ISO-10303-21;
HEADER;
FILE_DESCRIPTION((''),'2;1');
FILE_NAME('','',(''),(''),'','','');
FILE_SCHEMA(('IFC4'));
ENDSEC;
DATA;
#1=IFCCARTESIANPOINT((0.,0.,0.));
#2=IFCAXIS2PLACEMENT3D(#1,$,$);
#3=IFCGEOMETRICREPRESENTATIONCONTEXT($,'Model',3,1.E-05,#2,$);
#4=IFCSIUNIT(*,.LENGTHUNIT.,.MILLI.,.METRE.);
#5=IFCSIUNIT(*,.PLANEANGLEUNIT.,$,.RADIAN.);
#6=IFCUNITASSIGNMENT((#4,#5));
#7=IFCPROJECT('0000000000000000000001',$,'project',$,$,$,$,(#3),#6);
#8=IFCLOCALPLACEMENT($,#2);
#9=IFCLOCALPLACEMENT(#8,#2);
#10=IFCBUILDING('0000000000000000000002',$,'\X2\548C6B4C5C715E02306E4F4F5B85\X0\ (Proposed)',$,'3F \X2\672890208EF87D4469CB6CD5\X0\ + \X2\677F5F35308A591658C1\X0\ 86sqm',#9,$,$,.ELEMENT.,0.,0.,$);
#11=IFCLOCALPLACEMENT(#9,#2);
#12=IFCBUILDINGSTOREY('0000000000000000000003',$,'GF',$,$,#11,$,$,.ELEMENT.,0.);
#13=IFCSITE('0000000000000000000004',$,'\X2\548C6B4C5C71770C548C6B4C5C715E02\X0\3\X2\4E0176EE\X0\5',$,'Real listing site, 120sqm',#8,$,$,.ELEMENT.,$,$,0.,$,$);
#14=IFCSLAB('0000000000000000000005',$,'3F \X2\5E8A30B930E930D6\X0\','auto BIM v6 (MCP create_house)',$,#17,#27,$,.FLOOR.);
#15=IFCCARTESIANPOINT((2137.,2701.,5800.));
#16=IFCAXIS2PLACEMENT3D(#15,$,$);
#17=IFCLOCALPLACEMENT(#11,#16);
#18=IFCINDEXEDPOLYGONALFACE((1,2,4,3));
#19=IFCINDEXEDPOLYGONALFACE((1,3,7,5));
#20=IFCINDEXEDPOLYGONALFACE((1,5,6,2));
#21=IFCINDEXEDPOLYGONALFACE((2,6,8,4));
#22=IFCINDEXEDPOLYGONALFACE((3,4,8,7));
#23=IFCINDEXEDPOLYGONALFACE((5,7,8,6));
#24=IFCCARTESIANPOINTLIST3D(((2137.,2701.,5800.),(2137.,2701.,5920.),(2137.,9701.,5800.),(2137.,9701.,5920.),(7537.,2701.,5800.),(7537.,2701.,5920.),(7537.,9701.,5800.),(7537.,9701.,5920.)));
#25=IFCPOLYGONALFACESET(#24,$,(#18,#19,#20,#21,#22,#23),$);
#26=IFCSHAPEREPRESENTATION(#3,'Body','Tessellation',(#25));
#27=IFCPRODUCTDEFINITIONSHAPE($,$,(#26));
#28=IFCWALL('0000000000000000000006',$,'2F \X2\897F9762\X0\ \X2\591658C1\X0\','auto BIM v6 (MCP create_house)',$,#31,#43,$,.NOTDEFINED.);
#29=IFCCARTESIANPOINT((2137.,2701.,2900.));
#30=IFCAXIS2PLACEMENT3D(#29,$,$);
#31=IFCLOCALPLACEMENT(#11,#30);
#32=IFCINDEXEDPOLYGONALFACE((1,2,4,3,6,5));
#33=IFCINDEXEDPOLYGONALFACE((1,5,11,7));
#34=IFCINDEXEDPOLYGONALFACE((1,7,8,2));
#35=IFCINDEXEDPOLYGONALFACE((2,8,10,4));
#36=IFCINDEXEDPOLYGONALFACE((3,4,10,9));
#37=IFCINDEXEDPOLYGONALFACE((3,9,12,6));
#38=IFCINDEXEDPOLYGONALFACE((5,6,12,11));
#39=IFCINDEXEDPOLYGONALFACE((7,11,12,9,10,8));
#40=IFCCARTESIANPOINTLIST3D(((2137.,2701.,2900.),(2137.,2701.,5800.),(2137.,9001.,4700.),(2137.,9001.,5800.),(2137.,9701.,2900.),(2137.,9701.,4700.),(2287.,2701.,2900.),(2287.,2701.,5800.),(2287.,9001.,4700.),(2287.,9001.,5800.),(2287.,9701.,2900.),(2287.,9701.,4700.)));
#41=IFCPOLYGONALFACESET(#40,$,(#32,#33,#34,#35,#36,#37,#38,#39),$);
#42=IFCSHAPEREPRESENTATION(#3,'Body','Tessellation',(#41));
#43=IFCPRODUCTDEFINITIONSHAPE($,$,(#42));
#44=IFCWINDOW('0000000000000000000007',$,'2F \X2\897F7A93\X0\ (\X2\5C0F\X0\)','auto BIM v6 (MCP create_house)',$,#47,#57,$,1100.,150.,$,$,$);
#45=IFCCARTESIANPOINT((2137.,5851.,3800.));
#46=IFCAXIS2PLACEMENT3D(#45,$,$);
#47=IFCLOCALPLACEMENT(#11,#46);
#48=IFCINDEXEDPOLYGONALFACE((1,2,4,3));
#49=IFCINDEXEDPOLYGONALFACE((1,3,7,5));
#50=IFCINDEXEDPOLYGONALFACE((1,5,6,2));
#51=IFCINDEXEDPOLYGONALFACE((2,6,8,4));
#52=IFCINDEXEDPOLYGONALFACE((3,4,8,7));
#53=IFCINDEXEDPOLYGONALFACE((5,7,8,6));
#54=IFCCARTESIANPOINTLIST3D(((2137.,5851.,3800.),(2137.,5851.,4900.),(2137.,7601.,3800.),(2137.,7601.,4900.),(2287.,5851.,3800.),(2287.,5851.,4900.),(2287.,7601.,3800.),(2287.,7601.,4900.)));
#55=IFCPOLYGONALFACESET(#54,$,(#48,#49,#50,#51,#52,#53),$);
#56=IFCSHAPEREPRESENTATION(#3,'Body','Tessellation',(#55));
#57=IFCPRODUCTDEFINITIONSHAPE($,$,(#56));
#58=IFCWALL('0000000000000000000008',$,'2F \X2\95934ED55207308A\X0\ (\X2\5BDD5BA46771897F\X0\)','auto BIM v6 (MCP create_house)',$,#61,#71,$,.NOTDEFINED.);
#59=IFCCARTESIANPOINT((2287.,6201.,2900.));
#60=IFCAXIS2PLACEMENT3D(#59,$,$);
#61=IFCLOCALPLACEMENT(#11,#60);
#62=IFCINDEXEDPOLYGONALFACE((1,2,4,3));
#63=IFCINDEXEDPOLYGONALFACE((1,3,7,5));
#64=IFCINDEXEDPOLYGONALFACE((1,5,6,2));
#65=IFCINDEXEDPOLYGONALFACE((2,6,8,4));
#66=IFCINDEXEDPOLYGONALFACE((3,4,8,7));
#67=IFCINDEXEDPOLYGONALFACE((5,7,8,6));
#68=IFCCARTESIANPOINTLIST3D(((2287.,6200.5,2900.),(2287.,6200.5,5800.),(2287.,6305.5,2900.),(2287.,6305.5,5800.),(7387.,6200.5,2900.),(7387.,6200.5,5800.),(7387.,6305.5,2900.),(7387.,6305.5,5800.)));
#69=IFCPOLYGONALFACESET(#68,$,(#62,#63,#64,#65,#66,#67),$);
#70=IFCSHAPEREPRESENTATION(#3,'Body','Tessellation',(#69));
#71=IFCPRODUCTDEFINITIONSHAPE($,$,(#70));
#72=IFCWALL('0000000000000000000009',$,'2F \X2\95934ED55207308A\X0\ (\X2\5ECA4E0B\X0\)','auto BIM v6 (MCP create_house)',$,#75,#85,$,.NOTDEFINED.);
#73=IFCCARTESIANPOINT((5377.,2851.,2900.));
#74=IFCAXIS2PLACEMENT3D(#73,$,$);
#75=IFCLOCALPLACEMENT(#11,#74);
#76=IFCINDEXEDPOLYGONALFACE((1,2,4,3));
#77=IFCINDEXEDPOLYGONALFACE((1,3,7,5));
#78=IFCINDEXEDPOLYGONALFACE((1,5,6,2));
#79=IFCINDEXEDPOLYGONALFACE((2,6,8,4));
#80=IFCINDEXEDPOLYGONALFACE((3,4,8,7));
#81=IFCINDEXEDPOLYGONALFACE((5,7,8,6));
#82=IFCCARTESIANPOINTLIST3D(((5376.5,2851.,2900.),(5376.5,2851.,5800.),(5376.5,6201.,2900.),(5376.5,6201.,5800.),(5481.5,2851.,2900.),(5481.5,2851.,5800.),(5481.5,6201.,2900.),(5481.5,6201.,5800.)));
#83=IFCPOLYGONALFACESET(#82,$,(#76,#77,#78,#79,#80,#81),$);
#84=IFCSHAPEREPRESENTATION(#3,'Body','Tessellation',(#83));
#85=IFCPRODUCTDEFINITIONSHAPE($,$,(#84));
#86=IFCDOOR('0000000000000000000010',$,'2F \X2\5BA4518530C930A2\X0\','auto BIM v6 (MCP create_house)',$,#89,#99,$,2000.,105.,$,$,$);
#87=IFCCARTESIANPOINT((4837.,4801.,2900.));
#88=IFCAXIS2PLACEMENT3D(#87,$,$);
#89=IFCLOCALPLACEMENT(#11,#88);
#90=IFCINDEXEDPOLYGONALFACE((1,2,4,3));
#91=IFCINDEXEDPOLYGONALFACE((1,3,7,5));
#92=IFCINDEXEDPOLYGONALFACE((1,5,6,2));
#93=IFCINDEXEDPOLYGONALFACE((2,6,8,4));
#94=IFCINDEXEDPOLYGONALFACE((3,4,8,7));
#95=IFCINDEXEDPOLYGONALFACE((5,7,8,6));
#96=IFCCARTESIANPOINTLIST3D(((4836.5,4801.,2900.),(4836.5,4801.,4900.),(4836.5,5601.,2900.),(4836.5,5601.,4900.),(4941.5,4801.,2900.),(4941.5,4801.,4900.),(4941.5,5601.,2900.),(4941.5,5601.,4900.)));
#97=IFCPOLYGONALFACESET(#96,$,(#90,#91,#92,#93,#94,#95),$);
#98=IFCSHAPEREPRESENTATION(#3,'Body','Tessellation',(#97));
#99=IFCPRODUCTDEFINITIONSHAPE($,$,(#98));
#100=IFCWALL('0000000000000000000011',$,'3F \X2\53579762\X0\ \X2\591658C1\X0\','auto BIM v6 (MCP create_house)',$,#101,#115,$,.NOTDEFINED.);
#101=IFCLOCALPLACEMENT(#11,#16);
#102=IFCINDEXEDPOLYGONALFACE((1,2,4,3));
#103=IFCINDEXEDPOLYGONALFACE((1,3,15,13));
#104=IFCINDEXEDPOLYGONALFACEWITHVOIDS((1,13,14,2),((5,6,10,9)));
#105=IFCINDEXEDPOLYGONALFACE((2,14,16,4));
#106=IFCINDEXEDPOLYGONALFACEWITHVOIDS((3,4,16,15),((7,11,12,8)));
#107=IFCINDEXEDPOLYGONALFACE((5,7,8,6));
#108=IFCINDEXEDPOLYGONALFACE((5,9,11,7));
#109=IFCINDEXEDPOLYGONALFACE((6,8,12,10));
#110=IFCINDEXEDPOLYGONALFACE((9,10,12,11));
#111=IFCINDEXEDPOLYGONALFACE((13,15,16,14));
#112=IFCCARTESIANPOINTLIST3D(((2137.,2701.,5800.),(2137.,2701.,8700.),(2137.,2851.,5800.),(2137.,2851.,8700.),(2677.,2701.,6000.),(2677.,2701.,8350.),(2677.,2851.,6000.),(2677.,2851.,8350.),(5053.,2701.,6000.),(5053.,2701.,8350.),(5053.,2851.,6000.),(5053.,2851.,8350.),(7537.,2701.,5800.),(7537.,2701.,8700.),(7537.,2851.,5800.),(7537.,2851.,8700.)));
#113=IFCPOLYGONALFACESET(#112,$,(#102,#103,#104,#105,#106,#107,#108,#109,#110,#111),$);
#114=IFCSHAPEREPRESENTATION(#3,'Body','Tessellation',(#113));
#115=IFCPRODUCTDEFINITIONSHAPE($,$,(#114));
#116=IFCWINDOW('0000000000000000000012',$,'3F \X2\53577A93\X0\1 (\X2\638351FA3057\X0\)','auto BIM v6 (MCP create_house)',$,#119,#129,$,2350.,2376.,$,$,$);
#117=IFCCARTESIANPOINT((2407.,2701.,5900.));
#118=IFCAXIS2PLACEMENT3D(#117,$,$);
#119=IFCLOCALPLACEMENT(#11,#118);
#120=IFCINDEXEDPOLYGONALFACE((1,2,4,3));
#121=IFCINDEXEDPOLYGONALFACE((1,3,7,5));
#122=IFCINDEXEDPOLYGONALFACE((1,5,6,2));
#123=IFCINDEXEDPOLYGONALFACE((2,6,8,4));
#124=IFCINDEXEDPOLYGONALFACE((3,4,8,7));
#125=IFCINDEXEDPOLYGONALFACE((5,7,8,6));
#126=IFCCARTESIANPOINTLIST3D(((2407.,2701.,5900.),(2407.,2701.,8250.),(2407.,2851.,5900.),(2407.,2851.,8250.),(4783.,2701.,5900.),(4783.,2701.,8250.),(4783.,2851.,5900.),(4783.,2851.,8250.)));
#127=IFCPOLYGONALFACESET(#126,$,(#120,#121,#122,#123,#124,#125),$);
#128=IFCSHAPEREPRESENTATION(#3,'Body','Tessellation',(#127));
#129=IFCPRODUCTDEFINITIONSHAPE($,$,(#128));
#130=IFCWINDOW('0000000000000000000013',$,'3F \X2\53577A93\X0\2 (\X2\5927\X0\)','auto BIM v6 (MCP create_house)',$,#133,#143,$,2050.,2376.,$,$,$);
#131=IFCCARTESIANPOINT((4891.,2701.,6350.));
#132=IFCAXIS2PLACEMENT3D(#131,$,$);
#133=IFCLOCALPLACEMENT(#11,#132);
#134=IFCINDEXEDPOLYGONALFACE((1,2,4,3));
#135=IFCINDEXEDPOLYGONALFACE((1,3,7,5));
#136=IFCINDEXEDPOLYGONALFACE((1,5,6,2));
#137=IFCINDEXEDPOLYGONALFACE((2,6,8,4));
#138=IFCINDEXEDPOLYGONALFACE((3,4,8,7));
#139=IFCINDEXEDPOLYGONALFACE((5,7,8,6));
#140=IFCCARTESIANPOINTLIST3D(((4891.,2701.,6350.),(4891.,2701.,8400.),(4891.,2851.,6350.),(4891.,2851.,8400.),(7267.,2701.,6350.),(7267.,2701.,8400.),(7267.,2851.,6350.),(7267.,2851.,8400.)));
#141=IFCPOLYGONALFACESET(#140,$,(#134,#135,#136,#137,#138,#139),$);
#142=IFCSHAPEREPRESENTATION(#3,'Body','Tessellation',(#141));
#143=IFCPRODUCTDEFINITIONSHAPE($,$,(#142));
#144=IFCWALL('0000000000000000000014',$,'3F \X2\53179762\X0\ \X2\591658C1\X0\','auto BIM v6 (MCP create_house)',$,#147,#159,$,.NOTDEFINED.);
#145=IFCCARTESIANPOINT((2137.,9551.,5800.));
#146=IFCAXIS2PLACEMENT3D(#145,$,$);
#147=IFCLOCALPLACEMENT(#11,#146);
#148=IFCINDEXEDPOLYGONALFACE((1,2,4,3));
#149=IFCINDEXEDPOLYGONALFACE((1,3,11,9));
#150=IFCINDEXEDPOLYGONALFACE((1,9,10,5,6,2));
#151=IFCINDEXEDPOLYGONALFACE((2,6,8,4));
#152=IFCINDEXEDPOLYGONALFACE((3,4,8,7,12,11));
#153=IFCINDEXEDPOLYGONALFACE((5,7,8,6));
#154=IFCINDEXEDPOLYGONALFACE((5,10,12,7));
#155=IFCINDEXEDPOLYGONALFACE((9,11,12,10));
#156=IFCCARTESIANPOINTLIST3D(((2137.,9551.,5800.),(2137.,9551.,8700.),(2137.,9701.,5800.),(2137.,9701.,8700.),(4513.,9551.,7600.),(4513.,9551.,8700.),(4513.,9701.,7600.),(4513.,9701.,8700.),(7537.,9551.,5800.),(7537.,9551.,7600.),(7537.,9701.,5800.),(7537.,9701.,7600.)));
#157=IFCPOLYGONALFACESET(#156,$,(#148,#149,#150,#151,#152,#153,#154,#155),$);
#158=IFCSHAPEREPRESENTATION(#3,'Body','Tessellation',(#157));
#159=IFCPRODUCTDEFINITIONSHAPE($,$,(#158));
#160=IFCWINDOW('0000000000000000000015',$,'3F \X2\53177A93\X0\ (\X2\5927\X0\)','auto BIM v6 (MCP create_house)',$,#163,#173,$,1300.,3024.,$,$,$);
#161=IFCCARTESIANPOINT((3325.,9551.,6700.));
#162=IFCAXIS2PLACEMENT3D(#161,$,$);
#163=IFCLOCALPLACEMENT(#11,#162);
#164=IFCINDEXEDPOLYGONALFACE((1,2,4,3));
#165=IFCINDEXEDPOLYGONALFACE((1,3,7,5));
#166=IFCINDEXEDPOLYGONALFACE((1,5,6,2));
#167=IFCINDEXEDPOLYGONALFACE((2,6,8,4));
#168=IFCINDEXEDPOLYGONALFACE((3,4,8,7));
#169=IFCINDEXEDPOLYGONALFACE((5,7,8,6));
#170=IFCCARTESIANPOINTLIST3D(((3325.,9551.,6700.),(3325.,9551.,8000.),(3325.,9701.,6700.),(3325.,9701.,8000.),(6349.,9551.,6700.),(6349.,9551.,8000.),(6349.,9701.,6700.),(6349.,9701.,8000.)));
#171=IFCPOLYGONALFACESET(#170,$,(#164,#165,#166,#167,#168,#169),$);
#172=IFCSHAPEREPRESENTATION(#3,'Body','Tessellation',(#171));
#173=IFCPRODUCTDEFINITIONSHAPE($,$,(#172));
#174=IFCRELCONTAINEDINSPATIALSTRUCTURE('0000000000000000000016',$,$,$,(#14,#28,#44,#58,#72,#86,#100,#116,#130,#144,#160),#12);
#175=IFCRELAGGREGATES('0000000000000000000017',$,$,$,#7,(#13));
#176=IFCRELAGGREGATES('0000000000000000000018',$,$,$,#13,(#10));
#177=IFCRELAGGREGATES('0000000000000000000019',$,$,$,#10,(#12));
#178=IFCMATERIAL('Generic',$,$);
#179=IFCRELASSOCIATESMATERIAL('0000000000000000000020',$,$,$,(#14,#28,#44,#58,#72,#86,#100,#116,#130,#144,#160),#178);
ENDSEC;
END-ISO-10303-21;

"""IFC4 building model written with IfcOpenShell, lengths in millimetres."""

from ifc_helpers import new_model, si_unit, frame, frame_2d, origin, place, context, project, spatial, rectangle, extrude, material, element, fill, save


model = new_model("IFC4")

# Units and contexts
model_context = context("Model", 3, precision=1e-05, world=origin())
ifc_project = project(units=[si_unit("LENGTHUNIT", "METRE", prefix="MILLI"), si_unit("PLANEANGLEUNIT", "RADIAN")], contexts=[model_context])

# Site, building, storey
site_placement = place(None, origin())
site = spatial("IfcSite", under=ifc_project, at=site_placement, Name="和歌山県和歌山市3丁目5", ObjectType="Real listing site, 120sqm", CompositionType="ELEMENT", RefElevation=0.0)
building_placement = place(site_placement, origin())
building = spatial("IfcBuilding", under=site, at=building_placement, Name="和歌山市の住宅 (Proposed)", ObjectType="3F 木造軸組構法 + 板張り外壁 86sqm", CompositionType="ELEMENT", ElevationOfRefHeight=0.0, ElevationOfTerrain=0.0)
storey_placement = place(building_placement, origin())
storey = spatial("IfcBuildingStorey", under=building, at=storey_placement, Name="GF", CompositionType="ELEMENT", Elevation=0.0)

# Slab
ifc_material = material(Name="Generic")
slab_placement = place(storey_placement, frame((2137.0, 2701.0, 5800.0)))
element("IfcSlab", 1, at=slab_placement, inside=storey, material=ifc_material, Name="3F 床スラブ", Description="auto BIM v6 (MCP create_house)", PredefinedType="FLOOR", context=model_context, shape_type="SweptSolid", body=[
    extrude(rectangle(XDim=5400.0, YDim=7000.0, at=frame_2d((2700.0, 3500.0))), frame((2137.0, 2701.0, 5800.0)), (0.0, 0.0, 1.0), 120.0),
])

# Wall, opening, window
wall_1_placement = place(storey_placement, frame((2137.0, 2701.0, 2900.0)))
wall_1 = element("IfcWall", 2, at=wall_1_placement, inside=storey, material=ifc_material, Name="2F 西面 外壁", Description="auto BIM v6 (MCP create_house)", PredefinedType="NOTDEFINED", context=model_context, shape_type="SweptSolid", body=[
    extrude(rectangle(XDim=150.0, YDim=7000.0, at=frame_2d((75.0, 3500.0))), frame((2137.0, 2701.0, 2900.0)), (0.0, 0.0, 1.0), 2900.0),
])
opening_1_placement = place(storey_placement, frame((2137.0, 5851.0, 3800.0)))
opening_1 = element("IfcOpeningElement", 3, at=opening_1_placement, cuts=wall_1, PredefinedType="NOTDEFINED", context=model_context, shape_type="SweptSolid", body=[
    extrude(rectangle(XDim=150.0, YDim=1750.0, at=frame_2d((75.0, 875.0))), frame((2137.0, 5851.0, 3800.0)), (0.0, 0.0, 1.0), 1100.0),
])
window_1_placement = place(storey_placement, frame((2137.0, 5851.0, 3800.0)))
window_1 = element("IfcWindow", 4, at=window_1_placement, inside=storey, material=ifc_material, Name="2F 西窓 (小)", Description="auto BIM v6 (MCP create_house)", OverallHeight=1100.0, OverallWidth=150.0, context=model_context, shape_type="SweptSolid", body=[
    extrude(rectangle(XDim=150.0, YDim=1750.0, at=frame_2d((75.0, 875.0))), frame((2137.0, 5851.0, 3800.0)), (0.0, 0.0, 1.0), 1100.0),
])
fill(opening_1, window_1)

# Walls
wall_2_placement = place(storey_placement, frame((2287.0, 6201.0, 2900.0)))
element("IfcWall", 5, at=wall_2_placement, inside=storey, material=ifc_material, Name="2F 間仕切り (寝室東西)", Description="auto BIM v6 (MCP create_house)", PredefinedType="NOTDEFINED", context=model_context, shape_type="SweptSolid", body=[
    extrude(rectangle(XDim=5100.0, YDim=105.0, at=frame_2d((2550.0, 52.0))), frame((2287.0, 6201.0, 2900.0)), (0.0, 0.0, 1.0), 2900.0),
])
wall_3_placement = place(storey_placement, frame((5377.0, 2851.0, 2900.0)))
element("IfcWall", 6, at=wall_3_placement, inside=storey, material=ifc_material, Name="2F 間仕切り (廊下)", Description="auto BIM v6 (MCP create_house)", PredefinedType="NOTDEFINED", context=model_context, shape_type="SweptSolid", body=[
    extrude(rectangle(XDim=105.0, YDim=3350.0, at=frame_2d((52.0, 1675.0))), frame((5377.0, 2851.0, 2900.0)), (0.0, 0.0, 1.0), 2900.0),
])

# Door
door_1_placement = place(storey_placement, frame((4837.0, 4801.0, 2900.0)))
element("IfcDoor", 7, at=door_1_placement, inside=storey, material=ifc_material, Name="2F 室内ドア", Description="auto BIM v6 (MCP create_house)", OverallHeight=2000.0, OverallWidth=105.0, context=model_context, shape_type="SweptSolid", body=[
    extrude(rectangle(XDim=105.0, YDim=800.0, at=frame_2d((52.0, 400.0))), frame((4837.0, 4801.0, 2900.0)), (0.0, 0.0, 1.0), 2000.0),
])

# Wall, openings, windows
wall_4_placement = place(storey_placement, frame((2137.0, 2701.0, 5800.0)))
wall_4 = element("IfcWall", 8, at=wall_4_placement, inside=storey, material=ifc_material, Name="3F 南面 外壁", Description="auto BIM v6 (MCP create_house)", PredefinedType="NOTDEFINED", context=model_context, shape_type="SweptSolid", body=[
    extrude(rectangle(XDim=5400.0, YDim=150.0, at=frame_2d((2700.0, 75.0))), frame((2137.0, 2701.0, 5800.0)), (0.0, 0.0, 1.0), 2900.0),
])
opening_2_placement = place(storey_placement, frame((2407.0, 2701.0, 5900.0)))
opening_2 = element("IfcOpeningElement", 9, at=opening_2_placement, cuts=wall_4, PredefinedType="NOTDEFINED", context=model_context, shape_type="SweptSolid", body=[
    extrude(rectangle(XDim=2376.0, YDim=150.0, at=frame_2d((1188.0, 75.0))), frame((2407.0, 2701.0, 5900.0)), (0.0, 0.0, 1.0), 2350.0),
])
opening_3_placement = place(storey_placement, frame((4891.0, 2701.0, 6350.0)))
opening_3 = element("IfcOpeningElement", 10, at=opening_3_placement, cuts=wall_4, PredefinedType="NOTDEFINED", context=model_context, shape_type="SweptSolid", body=[
    extrude(rectangle(XDim=2376.0, YDim=150.0, at=frame_2d((1188.0, 75.0))), frame((4891.0, 2701.0, 6350.0)), (0.0, 0.0, 1.0), 2050.0),
])
window_2_placement = place(storey_placement, frame((2407.0, 2701.0, 5900.0)))
window_2 = element("IfcWindow", 11, at=window_2_placement, inside=storey, material=ifc_material, Name="3F 南窓1 (掃出し)", Description="auto BIM v6 (MCP create_house)", OverallHeight=2350.0, OverallWidth=2376.0, context=model_context, shape_type="SweptSolid", body=[
    extrude(rectangle(XDim=2376.0, YDim=150.0, at=frame_2d((1188.0, 75.0))), frame((2407.0, 2701.0, 5900.0)), (0.0, 0.0, 1.0), 2350.0),
])
fill(opening_2, window_2)
window_3_placement = place(storey_placement, frame((4891.0, 2701.0, 6350.0)))
window_3 = element("IfcWindow", 12, at=window_3_placement, inside=storey, material=ifc_material, Name="3F 南窓2 (大)", Description="auto BIM v6 (MCP create_house)", OverallHeight=2050.0, OverallWidth=2376.0, context=model_context, shape_type="SweptSolid", body=[
    extrude(rectangle(XDim=2376.0, YDim=150.0, at=frame_2d((1188.0, 75.0))), frame((4891.0, 2701.0, 6350.0)), (0.0, 0.0, 1.0), 2050.0),
])
fill(opening_3, window_3)

# Wall, opening, window
wall_5_placement = place(storey_placement, frame((2137.0, 9551.0, 5800.0)))
wall_5 = element("IfcWall", 13, at=wall_5_placement, inside=storey, material=ifc_material, Name="3F 北面 外壁", Description="auto BIM v6 (MCP create_house)", PredefinedType="NOTDEFINED", context=model_context, shape_type="SweptSolid", body=[
    extrude(rectangle(XDim=5400.0, YDim=150.0, at=frame_2d((2700.0, 75.0))), frame((2137.0, 9551.0, 5800.0)), (0.0, 0.0, 1.0), 2900.0),
])
opening_4_placement = place(storey_placement, frame((3325.0, 9551.0, 6700.0)))
opening_4 = element("IfcOpeningElement", 14, at=opening_4_placement, cuts=wall_5, PredefinedType="NOTDEFINED", context=model_context, shape_type="SweptSolid", body=[
    extrude(rectangle(XDim=3024.0, YDim=150.0, at=frame_2d((1512.0, 75.0))), frame((3325.0, 9551.0, 6700.0)), (0.0, 0.0, 1.0), 1300.0),
])
window_4_placement = place(storey_placement, frame((3325.0, 9551.0, 6700.0)))
window_4 = element("IfcWindow", 15, at=window_4_placement, inside=storey, material=ifc_material, Name="3F 北窓 (大)", Description="auto BIM v6 (MCP create_house)", OverallHeight=1300.0, OverallWidth=3024.0, context=model_context, shape_type="SweptSolid", body=[
    extrude(rectangle(XDim=3024.0, YDim=150.0, at=frame_2d((1512.0, 75.0))), frame((3325.0, 9551.0, 6700.0)), (0.0, 0.0, 1.0), 1300.0),
])
fill(opening_4, window_4)

save(model, "model.ifc")
